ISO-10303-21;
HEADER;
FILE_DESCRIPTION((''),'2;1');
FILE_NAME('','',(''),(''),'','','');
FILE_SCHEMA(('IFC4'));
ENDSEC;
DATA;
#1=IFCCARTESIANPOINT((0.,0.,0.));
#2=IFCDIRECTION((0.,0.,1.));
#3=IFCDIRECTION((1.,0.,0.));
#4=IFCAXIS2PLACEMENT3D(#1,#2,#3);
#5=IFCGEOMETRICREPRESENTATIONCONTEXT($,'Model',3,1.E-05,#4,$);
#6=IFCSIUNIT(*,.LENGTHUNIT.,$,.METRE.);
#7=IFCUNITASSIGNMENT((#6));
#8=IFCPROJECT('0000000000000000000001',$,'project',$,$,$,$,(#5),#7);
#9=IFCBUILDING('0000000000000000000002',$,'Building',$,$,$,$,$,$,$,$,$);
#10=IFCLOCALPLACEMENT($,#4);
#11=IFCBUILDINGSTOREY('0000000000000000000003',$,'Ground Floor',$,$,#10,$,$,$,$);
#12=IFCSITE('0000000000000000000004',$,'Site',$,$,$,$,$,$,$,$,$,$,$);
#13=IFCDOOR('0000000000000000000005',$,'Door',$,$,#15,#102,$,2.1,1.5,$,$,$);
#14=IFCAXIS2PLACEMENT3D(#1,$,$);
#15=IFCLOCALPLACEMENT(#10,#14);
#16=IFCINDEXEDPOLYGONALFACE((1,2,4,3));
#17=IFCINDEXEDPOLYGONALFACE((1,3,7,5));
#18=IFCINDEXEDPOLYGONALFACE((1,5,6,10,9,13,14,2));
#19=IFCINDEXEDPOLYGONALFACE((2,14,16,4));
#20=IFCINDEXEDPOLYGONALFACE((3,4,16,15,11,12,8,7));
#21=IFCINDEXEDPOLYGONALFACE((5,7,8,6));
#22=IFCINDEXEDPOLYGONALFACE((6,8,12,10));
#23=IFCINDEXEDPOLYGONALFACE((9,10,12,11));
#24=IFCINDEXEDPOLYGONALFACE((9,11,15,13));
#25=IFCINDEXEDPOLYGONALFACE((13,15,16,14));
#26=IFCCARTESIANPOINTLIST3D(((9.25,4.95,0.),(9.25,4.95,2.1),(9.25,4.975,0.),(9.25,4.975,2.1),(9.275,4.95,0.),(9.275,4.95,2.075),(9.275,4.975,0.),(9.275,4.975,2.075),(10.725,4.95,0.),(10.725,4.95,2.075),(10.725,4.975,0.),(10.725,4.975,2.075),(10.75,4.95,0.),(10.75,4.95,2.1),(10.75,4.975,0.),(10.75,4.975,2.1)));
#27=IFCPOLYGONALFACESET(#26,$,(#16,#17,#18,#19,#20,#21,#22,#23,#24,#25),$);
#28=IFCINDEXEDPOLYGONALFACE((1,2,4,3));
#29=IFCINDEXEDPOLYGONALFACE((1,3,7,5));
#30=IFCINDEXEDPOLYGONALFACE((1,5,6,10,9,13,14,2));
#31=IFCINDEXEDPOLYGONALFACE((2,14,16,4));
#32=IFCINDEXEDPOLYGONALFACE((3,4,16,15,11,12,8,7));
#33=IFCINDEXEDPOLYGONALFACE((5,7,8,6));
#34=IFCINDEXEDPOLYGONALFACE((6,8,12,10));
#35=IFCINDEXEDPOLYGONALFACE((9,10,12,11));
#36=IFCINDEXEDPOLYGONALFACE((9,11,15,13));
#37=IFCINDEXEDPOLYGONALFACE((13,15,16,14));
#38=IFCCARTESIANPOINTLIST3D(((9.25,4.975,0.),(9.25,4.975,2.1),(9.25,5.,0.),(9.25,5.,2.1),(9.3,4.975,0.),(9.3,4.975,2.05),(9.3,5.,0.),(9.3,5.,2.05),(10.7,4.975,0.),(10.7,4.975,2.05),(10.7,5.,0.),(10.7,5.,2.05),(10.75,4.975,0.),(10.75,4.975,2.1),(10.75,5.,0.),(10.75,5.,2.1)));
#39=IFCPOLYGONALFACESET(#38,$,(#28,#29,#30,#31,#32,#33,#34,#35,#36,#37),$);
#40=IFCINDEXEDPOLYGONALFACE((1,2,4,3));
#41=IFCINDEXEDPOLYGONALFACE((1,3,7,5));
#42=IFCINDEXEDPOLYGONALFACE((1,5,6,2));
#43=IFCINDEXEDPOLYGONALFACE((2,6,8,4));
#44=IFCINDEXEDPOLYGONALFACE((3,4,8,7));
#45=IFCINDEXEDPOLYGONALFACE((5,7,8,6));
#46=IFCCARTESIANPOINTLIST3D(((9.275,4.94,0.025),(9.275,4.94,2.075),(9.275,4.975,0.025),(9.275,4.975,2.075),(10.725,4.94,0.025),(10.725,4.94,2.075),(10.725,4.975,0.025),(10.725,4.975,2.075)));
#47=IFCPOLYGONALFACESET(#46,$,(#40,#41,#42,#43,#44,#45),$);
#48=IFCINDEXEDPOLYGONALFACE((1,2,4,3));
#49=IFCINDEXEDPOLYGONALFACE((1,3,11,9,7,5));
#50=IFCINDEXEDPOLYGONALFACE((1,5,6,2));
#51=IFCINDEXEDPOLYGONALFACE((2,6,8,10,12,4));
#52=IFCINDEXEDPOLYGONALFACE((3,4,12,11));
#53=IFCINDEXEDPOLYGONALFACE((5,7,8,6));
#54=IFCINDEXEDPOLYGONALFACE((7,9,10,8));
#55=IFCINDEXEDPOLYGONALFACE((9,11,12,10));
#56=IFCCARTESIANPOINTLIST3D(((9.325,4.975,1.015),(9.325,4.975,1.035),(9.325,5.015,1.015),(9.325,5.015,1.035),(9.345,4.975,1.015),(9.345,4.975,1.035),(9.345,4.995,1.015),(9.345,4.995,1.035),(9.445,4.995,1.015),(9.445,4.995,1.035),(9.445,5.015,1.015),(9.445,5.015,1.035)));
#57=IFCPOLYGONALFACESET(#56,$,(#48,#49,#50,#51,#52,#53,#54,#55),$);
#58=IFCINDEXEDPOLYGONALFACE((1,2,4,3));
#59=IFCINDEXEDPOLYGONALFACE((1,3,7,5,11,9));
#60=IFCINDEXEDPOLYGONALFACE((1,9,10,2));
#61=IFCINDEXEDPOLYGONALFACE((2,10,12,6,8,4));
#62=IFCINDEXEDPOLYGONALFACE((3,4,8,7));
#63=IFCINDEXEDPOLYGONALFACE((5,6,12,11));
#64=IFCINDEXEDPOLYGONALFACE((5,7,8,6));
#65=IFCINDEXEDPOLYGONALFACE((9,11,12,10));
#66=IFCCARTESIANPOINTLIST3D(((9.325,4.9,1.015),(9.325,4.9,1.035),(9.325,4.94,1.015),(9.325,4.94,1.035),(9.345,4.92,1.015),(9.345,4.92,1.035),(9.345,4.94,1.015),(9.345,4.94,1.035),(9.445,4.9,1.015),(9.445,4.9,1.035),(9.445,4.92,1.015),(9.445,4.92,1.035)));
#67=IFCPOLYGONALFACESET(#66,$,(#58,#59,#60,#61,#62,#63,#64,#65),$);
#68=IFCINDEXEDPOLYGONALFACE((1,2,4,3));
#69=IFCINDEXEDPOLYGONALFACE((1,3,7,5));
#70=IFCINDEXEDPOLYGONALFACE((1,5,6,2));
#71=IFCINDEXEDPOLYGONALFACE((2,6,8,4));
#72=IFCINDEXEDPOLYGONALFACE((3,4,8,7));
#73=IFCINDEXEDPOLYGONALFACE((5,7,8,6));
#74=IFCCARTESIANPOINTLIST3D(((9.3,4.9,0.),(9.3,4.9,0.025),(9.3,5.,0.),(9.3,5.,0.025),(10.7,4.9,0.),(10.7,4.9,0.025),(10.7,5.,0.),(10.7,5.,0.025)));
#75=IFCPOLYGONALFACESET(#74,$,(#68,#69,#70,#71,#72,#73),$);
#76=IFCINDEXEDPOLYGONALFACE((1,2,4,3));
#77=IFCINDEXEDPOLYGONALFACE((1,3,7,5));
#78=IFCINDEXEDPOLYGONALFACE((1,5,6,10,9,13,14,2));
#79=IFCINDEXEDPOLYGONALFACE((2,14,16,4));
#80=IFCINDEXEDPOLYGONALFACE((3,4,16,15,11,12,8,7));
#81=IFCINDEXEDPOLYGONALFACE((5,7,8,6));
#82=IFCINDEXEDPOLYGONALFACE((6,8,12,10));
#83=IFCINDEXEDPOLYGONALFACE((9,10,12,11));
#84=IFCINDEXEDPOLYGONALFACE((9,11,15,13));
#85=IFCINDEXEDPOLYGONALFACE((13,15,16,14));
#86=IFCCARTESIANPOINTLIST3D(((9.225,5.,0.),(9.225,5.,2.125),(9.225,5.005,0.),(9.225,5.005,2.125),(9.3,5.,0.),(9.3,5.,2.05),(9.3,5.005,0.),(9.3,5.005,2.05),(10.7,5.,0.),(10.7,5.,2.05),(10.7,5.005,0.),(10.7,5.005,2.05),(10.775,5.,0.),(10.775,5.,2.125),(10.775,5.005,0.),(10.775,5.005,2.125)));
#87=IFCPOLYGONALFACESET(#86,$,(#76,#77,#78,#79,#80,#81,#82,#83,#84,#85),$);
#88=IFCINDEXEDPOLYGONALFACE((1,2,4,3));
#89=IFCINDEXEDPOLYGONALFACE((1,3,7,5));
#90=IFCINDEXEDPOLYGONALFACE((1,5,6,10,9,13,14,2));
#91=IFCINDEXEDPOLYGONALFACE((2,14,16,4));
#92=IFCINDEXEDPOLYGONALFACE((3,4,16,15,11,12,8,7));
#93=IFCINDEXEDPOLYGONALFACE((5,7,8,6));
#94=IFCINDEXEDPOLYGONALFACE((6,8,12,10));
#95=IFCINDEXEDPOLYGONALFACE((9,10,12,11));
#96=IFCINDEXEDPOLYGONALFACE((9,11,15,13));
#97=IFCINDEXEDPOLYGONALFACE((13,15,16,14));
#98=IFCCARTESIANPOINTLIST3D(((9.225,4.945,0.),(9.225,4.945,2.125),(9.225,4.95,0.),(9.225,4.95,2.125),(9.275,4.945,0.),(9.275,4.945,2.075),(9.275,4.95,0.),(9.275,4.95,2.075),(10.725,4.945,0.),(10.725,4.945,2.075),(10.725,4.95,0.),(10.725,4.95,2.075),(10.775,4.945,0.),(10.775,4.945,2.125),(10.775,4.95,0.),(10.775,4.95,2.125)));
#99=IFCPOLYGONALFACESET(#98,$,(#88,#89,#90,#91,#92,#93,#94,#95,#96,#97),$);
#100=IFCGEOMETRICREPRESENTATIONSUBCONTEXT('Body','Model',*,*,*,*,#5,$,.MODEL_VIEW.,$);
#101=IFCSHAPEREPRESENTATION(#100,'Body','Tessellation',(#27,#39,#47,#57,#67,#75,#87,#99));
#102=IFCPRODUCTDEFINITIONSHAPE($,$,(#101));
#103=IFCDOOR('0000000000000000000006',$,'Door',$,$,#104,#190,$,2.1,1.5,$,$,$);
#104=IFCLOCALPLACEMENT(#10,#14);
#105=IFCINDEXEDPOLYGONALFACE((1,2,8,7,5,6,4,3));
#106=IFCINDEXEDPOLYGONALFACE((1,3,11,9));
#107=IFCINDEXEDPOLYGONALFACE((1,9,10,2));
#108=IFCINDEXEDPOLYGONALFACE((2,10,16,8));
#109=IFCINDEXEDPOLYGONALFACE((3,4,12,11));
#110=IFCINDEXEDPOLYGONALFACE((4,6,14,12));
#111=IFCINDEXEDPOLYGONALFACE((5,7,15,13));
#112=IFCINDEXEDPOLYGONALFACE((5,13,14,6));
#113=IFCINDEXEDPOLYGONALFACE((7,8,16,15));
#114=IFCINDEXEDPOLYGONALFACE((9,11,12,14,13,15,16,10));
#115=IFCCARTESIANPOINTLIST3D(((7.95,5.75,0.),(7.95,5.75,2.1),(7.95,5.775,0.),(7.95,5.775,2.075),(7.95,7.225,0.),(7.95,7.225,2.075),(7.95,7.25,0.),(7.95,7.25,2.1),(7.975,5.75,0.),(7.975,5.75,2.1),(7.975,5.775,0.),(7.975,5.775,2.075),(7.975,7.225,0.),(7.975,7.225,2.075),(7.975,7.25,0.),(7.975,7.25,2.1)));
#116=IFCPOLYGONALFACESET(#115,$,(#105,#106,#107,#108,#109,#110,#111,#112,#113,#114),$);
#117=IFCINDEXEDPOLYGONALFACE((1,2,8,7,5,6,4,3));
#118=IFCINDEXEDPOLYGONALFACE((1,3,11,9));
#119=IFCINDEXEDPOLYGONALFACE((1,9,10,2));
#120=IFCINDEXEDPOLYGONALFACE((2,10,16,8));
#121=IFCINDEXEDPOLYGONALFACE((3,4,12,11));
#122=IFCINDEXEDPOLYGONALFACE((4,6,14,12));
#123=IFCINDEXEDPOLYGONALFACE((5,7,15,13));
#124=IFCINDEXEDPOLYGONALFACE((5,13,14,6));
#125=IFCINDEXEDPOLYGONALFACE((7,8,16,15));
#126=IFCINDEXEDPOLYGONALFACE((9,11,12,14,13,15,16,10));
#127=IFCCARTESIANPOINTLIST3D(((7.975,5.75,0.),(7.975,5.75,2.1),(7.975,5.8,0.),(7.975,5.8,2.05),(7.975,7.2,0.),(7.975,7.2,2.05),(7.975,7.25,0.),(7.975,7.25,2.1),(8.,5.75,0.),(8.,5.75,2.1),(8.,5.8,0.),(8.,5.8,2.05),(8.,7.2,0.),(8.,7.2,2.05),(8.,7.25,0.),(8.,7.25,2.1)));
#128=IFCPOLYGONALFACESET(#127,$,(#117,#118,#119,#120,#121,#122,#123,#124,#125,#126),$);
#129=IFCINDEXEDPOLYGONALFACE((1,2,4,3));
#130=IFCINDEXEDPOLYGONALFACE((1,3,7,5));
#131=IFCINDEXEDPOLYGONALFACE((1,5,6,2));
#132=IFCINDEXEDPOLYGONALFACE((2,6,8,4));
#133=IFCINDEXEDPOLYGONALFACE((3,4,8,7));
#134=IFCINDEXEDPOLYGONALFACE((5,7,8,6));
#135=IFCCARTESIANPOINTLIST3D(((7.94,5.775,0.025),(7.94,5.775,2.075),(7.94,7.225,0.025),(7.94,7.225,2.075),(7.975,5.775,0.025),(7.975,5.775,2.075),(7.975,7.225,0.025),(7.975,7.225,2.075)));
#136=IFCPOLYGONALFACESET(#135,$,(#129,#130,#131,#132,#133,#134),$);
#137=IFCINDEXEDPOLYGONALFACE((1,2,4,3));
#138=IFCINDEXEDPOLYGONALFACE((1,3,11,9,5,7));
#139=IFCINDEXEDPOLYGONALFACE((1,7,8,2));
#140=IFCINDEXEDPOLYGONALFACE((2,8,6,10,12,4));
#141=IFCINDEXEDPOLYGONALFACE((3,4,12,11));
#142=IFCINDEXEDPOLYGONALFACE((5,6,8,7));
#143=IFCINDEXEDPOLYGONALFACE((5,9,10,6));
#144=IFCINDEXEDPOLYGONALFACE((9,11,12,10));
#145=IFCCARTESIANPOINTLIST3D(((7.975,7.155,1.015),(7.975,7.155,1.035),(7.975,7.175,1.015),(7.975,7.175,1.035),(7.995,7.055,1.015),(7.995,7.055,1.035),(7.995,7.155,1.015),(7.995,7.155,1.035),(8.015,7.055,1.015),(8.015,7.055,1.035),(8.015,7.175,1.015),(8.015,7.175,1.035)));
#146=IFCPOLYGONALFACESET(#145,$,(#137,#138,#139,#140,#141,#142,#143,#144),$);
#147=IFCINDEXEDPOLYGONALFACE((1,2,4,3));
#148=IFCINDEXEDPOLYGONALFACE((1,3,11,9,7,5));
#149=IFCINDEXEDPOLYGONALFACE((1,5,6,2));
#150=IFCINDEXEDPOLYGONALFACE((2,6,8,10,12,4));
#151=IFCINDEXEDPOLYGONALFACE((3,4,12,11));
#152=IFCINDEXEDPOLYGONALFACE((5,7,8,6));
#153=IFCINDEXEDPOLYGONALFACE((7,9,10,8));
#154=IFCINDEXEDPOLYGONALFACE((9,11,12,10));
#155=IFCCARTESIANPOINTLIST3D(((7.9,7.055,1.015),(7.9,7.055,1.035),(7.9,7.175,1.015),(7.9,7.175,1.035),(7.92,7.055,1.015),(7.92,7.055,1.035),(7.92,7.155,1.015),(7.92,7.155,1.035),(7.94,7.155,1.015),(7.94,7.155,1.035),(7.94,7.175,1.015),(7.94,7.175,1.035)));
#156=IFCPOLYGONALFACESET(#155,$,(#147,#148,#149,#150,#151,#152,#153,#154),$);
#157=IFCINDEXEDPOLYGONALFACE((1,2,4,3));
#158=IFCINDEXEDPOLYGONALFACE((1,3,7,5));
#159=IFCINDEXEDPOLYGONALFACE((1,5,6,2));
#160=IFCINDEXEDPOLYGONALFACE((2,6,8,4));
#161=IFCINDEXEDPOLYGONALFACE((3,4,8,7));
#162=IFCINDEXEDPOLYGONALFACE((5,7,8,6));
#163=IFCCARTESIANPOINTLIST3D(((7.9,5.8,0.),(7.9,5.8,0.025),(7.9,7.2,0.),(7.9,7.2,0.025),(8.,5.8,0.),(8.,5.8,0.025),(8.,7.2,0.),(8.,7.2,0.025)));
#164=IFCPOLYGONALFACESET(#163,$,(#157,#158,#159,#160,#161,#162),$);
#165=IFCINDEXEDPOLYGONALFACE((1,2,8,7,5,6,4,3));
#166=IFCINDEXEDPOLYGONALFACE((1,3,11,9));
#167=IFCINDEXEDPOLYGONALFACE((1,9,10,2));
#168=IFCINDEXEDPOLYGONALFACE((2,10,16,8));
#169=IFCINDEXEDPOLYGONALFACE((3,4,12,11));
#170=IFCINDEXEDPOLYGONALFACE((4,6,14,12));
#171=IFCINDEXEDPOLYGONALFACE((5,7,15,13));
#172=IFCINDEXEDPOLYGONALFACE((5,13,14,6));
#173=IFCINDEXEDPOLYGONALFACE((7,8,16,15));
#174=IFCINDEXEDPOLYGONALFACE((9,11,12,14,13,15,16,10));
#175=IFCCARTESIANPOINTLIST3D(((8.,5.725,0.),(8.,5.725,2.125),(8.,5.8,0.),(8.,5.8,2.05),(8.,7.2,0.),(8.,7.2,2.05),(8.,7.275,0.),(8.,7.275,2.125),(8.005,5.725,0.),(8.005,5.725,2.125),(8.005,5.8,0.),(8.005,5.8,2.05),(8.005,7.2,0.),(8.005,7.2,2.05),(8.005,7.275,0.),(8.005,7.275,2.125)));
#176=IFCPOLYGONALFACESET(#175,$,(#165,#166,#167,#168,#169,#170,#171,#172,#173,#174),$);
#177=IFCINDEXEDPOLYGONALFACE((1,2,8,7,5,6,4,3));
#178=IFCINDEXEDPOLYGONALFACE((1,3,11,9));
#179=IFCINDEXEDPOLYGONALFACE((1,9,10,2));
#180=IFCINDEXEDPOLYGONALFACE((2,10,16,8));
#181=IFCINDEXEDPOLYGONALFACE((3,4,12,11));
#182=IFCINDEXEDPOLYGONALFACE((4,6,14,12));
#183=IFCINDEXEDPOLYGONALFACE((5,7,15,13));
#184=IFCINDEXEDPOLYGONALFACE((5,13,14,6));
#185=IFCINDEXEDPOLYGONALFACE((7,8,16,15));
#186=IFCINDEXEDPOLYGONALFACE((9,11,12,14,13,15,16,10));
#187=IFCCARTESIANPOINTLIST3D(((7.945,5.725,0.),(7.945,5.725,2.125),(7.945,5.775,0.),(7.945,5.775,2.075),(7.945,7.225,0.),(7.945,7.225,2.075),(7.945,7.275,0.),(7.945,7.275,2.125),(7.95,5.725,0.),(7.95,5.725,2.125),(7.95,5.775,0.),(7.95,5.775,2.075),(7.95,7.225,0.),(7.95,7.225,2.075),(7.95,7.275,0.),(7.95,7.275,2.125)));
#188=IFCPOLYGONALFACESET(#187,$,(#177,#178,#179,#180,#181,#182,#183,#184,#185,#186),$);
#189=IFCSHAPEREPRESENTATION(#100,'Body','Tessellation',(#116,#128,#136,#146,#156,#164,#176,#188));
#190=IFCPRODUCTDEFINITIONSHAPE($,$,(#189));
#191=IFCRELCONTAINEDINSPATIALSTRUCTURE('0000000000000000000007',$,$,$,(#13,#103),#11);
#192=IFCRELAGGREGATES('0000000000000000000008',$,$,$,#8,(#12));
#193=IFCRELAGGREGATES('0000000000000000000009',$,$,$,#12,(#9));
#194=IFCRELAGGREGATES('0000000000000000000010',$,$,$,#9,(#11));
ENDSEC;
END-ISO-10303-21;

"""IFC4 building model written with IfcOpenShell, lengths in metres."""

from ifc_helpers import new_model, si_unit, frame, origin_with_axes, place, context, subcontext, project, spatial, line, indexed_curve, outline, extrude, element, save


model = new_model("IFC4")

# Units and contexts
model_context = context("Model", 3, precision=1e-05, world=origin_with_axes())
body_context = subcontext(model_context, "Body", "Model", "MODEL_VIEW")
ifc_project = project(units=[si_unit("LENGTHUNIT", "METRE")], contexts=[model_context])

# Site, building, storey
site = spatial("IfcSite", under=ifc_project, Name="Site")
building = spatial("IfcBuilding", under=site, Name="Building")
storey_placement = place(None, origin_with_axes())
storey = spatial("IfcBuildingStorey", under=building, at=storey_placement, Name="Ground Floor")

# Doors
door_1_placement = place(storey_placement, frame((10.75, 5.0, 0.0), z_axis=(0.0, 0.0, 1.0), x_axis=(-1.0, 0.0, 0.0)))
element("IfcDoor", 1, at=door_1_placement, inside=storey, Name="Door", OverallHeight=2.1, OverallWidth=1.5, context=body_context, shape_type="SweptSolid", body=[
    extrude(outline(indexed_curve([(0.0, 0.0), (0.0, 2.1), (1.5, 2.1), (1.5, 0.0), (1.475, 0.0), (1.475, 2.075), (0.025, 2.075), (0.025, 0.0)], segments=[line(1, 2, 3, 4, 5, 6, 7, 8, 1)])), frame((0.0, 0.025, 0.0), z_axis=(0.0, -1.0, 0.0), x_axis=(1.0, 0.0, 0.0)), (0.0, 0.0, -1.0), 0.025),
    extrude(outline(indexed_curve([(0.0, 0.0), (0.0, 2.1), (1.5, 2.1), (1.5, 0.0), (1.45, 0.0), (1.45, 2.05), (0.05, 2.05), (0.05, 0.0)], segments=[line(1, 2, 3, 4, 5, 6, 7, 8, 1)])), frame((0.0, 0.0, 0.0), z_axis=(0.0, -1.0, 0.0), x_axis=(1.0, 0.0, 0.0)), (0.0, 0.0, -1.0), 0.025),
    extrude(outline(indexed_curve([(0.0, 0.0), (1.45, 0.0), (1.45, 0.035), (0.0, 0.035)], segments=[line(1, 2, 3, 4, 1)])), frame((0.025, 0.025, 0.025), z_axis=(0.0, 0.0, 1.0), x_axis=(1.0, 0.0, 0.0)), (0.0, 0.0, 1.0), 2.05),
    extrude(outline(indexed_curve([(0.0, 0.0), (0.0, -0.04), (-0.12, -0.04), (-0.12, -0.02), (-0.02, -0.02), (-0.02, 0.0)], segments=[line(1, 2, 3, 4, 5, 6, 1)])), frame((1.425, 0.025, 1.015), z_axis=(0.0, 0.0, 1.0), x_axis=(1.0, 0.0, 0.0)), (0.0, 0.0, 1.0), 0.02),
    extrude(outline(indexed_curve([(0.0, 0.0), (0.0, 0.04), (-0.12, 0.04), (-0.12, 0.02), (-0.02, 0.02), (-0.02, 0.0)], segments=[line(1, 2, 3, 4, 5, 6, 1)])), frame((1.425, 0.06, 1.015), z_axis=(0.0, 0.0, 1.0), x_axis=(1.0, 0.0, 0.0)), (0.0, 0.0, 1.0), 0.02),
    extrude(outline(indexed_curve([(0.0, 0.0), (1.4, 0.0), (1.4, 0.1), (0.0, 0.1)], segments=[line(1, 2, 3, 4, 1)])), frame((0.05, 0.0, 0.0), z_axis=(0.0, 0.0, 1.0), x_axis=(1.0, 0.0, 0.0)), (0.0, 0.0, 1.0), 0.025),
    extrude(outline(indexed_curve([(0.0, 0.0), (0.0, 2.125), (1.55, 2.125), (1.55, 0.0), (1.475, 0.0), (1.475, 2.05), (0.075, 2.05), (0.075, 0.0)], segments=[line(1, 2, 3, 4, 5, 6, 7, 8, 1)])), frame((-0.025, -0.005, 0.0), z_axis=(0.0, -1.0, 0.0), x_axis=(1.0, 0.0, 0.0)), (0.0, 0.0, -1.0), 0.005),
    extrude(outline(indexed_curve([(0.0, 0.0), (0.0, 2.125), (1.55, 2.125), (1.55, 0.0), (1.5, 0.0), (1.5, 2.075), (0.05, 2.075), (0.05, 0.0)], segments=[line(1, 2, 3, 4, 5, 6, 7, 8, 1)])), frame((-0.025, 0.05, 0.0), z_axis=(0.0, -1.0, 0.0), x_axis=(1.0, 0.0, 0.0)), (0.0, 0.0, -1.0), 0.005),
])
door_2_placement = place(storey_placement, frame((8.0, 5.75, 0.0), z_axis=(0.0, 0.0, 1.0), x_axis=(0.0, 1.0, 0.0)))
element("IfcDoor", 2, at=door_2_placement, inside=storey, Name="Door", OverallHeight=2.1, OverallWidth=1.5, context=body_context, shape_type="SweptSolid", body=[
    extrude(outline(indexed_curve([(0.0, 0.0), (0.0, 2.1), (1.5, 2.1), (1.5, 0.0), (1.475, 0.0), (1.475, 2.075), (0.025, 2.075), (0.025, 0.0)], segments=[line(1, 2, 3, 4, 5, 6, 7, 8, 1)])), frame((0.0, 0.025, 0.0), z_axis=(0.0, -1.0, 0.0), x_axis=(1.0, 0.0, 0.0)), (0.0, 0.0, -1.0), 0.025),
    extrude(outline(indexed_curve([(0.0, 0.0), (0.0, 2.1), (1.5, 2.1), (1.5, 0.0), (1.45, 0.0), (1.45, 2.05), (0.05, 2.05), (0.05, 0.0)], segments=[line(1, 2, 3, 4, 5, 6, 7, 8, 1)])), frame((0.0, 0.0, 0.0), z_axis=(0.0, -1.0, 0.0), x_axis=(1.0, 0.0, 0.0)), (0.0, 0.0, -1.0), 0.025),
    extrude(outline(indexed_curve([(0.0, 0.0), (1.45, 0.0), (1.45, 0.035), (0.0, 0.035)], segments=[line(1, 2, 3, 4, 1)])), frame((0.025, 0.025, 0.025), z_axis=(0.0, 0.0, 1.0), x_axis=(1.0, 0.0, 0.0)), (0.0, 0.0, 1.0), 2.05),
    extrude(outline(indexed_curve([(0.0, 0.0), (0.0, -0.04), (-0.12, -0.04), (-0.12, -0.02), (-0.02, -0.02), (-0.02, 0.0)], segments=[line(1, 2, 3, 4, 5, 6, 1)])), frame((1.425, 0.025, 1.015), z_axis=(0.0, 0.0, 1.0), x_axis=(1.0, 0.0, 0.0)), (0.0, 0.0, 1.0), 0.02),
    extrude(outline(indexed_curve([(0.0, 0.0), (0.0, 0.04), (-0.12, 0.04), (-0.12, 0.02), (-0.02, 0.02), (-0.02, 0.0)], segments=[line(1, 2, 3, 4, 5, 6, 1)])), frame((1.425, 0.06, 1.015), z_axis=(0.0, 0.0, 1.0), x_axis=(1.0, 0.0, 0.0)), (0.0, 0.0, 1.0), 0.02),
    extrude(outline(indexed_curve([(0.0, 0.0), (1.4, 0.0), (1.4, 0.1), (0.0, 0.1)], segments=[line(1, 2, 3, 4, 1)])), frame((0.05, 0.0, 0.0), z_axis=(0.0, 0.0, 1.0), x_axis=(1.0, 0.0, 0.0)), (0.0, 0.0, 1.0), 0.025),
    extrude(outline(indexed_curve([(0.0, 0.0), (0.0, 2.125), (1.55, 2.125), (1.55, 0.0), (1.475, 0.0), (1.475, 2.05), (0.075, 2.05), (0.075, 0.0)], segments=[line(1, 2, 3, 4, 5, 6, 7, 8, 1)])), frame((-0.025, -0.005, 0.0), z_axis=(0.0, -1.0, 0.0), x_axis=(1.0, 0.0, 0.0)), (0.0, 0.0, -1.0), 0.005),
    extrude(outline(indexed_curve([(0.0, 0.0), (0.0, 2.125), (1.55, 2.125), (1.55, 0.0), (1.5, 0.0), (1.5, 2.075), (0.05, 2.075), (0.05, 0.0)], segments=[line(1, 2, 3, 4, 5, 6, 7, 8, 1)])), frame((-0.025, 0.05, 0.0), z_axis=(0.0, -1.0, 0.0), x_axis=(1.0, 0.0, 0.0)), (0.0, 0.0, -1.0), 0.005),
])

save(model, "model.ifc")
